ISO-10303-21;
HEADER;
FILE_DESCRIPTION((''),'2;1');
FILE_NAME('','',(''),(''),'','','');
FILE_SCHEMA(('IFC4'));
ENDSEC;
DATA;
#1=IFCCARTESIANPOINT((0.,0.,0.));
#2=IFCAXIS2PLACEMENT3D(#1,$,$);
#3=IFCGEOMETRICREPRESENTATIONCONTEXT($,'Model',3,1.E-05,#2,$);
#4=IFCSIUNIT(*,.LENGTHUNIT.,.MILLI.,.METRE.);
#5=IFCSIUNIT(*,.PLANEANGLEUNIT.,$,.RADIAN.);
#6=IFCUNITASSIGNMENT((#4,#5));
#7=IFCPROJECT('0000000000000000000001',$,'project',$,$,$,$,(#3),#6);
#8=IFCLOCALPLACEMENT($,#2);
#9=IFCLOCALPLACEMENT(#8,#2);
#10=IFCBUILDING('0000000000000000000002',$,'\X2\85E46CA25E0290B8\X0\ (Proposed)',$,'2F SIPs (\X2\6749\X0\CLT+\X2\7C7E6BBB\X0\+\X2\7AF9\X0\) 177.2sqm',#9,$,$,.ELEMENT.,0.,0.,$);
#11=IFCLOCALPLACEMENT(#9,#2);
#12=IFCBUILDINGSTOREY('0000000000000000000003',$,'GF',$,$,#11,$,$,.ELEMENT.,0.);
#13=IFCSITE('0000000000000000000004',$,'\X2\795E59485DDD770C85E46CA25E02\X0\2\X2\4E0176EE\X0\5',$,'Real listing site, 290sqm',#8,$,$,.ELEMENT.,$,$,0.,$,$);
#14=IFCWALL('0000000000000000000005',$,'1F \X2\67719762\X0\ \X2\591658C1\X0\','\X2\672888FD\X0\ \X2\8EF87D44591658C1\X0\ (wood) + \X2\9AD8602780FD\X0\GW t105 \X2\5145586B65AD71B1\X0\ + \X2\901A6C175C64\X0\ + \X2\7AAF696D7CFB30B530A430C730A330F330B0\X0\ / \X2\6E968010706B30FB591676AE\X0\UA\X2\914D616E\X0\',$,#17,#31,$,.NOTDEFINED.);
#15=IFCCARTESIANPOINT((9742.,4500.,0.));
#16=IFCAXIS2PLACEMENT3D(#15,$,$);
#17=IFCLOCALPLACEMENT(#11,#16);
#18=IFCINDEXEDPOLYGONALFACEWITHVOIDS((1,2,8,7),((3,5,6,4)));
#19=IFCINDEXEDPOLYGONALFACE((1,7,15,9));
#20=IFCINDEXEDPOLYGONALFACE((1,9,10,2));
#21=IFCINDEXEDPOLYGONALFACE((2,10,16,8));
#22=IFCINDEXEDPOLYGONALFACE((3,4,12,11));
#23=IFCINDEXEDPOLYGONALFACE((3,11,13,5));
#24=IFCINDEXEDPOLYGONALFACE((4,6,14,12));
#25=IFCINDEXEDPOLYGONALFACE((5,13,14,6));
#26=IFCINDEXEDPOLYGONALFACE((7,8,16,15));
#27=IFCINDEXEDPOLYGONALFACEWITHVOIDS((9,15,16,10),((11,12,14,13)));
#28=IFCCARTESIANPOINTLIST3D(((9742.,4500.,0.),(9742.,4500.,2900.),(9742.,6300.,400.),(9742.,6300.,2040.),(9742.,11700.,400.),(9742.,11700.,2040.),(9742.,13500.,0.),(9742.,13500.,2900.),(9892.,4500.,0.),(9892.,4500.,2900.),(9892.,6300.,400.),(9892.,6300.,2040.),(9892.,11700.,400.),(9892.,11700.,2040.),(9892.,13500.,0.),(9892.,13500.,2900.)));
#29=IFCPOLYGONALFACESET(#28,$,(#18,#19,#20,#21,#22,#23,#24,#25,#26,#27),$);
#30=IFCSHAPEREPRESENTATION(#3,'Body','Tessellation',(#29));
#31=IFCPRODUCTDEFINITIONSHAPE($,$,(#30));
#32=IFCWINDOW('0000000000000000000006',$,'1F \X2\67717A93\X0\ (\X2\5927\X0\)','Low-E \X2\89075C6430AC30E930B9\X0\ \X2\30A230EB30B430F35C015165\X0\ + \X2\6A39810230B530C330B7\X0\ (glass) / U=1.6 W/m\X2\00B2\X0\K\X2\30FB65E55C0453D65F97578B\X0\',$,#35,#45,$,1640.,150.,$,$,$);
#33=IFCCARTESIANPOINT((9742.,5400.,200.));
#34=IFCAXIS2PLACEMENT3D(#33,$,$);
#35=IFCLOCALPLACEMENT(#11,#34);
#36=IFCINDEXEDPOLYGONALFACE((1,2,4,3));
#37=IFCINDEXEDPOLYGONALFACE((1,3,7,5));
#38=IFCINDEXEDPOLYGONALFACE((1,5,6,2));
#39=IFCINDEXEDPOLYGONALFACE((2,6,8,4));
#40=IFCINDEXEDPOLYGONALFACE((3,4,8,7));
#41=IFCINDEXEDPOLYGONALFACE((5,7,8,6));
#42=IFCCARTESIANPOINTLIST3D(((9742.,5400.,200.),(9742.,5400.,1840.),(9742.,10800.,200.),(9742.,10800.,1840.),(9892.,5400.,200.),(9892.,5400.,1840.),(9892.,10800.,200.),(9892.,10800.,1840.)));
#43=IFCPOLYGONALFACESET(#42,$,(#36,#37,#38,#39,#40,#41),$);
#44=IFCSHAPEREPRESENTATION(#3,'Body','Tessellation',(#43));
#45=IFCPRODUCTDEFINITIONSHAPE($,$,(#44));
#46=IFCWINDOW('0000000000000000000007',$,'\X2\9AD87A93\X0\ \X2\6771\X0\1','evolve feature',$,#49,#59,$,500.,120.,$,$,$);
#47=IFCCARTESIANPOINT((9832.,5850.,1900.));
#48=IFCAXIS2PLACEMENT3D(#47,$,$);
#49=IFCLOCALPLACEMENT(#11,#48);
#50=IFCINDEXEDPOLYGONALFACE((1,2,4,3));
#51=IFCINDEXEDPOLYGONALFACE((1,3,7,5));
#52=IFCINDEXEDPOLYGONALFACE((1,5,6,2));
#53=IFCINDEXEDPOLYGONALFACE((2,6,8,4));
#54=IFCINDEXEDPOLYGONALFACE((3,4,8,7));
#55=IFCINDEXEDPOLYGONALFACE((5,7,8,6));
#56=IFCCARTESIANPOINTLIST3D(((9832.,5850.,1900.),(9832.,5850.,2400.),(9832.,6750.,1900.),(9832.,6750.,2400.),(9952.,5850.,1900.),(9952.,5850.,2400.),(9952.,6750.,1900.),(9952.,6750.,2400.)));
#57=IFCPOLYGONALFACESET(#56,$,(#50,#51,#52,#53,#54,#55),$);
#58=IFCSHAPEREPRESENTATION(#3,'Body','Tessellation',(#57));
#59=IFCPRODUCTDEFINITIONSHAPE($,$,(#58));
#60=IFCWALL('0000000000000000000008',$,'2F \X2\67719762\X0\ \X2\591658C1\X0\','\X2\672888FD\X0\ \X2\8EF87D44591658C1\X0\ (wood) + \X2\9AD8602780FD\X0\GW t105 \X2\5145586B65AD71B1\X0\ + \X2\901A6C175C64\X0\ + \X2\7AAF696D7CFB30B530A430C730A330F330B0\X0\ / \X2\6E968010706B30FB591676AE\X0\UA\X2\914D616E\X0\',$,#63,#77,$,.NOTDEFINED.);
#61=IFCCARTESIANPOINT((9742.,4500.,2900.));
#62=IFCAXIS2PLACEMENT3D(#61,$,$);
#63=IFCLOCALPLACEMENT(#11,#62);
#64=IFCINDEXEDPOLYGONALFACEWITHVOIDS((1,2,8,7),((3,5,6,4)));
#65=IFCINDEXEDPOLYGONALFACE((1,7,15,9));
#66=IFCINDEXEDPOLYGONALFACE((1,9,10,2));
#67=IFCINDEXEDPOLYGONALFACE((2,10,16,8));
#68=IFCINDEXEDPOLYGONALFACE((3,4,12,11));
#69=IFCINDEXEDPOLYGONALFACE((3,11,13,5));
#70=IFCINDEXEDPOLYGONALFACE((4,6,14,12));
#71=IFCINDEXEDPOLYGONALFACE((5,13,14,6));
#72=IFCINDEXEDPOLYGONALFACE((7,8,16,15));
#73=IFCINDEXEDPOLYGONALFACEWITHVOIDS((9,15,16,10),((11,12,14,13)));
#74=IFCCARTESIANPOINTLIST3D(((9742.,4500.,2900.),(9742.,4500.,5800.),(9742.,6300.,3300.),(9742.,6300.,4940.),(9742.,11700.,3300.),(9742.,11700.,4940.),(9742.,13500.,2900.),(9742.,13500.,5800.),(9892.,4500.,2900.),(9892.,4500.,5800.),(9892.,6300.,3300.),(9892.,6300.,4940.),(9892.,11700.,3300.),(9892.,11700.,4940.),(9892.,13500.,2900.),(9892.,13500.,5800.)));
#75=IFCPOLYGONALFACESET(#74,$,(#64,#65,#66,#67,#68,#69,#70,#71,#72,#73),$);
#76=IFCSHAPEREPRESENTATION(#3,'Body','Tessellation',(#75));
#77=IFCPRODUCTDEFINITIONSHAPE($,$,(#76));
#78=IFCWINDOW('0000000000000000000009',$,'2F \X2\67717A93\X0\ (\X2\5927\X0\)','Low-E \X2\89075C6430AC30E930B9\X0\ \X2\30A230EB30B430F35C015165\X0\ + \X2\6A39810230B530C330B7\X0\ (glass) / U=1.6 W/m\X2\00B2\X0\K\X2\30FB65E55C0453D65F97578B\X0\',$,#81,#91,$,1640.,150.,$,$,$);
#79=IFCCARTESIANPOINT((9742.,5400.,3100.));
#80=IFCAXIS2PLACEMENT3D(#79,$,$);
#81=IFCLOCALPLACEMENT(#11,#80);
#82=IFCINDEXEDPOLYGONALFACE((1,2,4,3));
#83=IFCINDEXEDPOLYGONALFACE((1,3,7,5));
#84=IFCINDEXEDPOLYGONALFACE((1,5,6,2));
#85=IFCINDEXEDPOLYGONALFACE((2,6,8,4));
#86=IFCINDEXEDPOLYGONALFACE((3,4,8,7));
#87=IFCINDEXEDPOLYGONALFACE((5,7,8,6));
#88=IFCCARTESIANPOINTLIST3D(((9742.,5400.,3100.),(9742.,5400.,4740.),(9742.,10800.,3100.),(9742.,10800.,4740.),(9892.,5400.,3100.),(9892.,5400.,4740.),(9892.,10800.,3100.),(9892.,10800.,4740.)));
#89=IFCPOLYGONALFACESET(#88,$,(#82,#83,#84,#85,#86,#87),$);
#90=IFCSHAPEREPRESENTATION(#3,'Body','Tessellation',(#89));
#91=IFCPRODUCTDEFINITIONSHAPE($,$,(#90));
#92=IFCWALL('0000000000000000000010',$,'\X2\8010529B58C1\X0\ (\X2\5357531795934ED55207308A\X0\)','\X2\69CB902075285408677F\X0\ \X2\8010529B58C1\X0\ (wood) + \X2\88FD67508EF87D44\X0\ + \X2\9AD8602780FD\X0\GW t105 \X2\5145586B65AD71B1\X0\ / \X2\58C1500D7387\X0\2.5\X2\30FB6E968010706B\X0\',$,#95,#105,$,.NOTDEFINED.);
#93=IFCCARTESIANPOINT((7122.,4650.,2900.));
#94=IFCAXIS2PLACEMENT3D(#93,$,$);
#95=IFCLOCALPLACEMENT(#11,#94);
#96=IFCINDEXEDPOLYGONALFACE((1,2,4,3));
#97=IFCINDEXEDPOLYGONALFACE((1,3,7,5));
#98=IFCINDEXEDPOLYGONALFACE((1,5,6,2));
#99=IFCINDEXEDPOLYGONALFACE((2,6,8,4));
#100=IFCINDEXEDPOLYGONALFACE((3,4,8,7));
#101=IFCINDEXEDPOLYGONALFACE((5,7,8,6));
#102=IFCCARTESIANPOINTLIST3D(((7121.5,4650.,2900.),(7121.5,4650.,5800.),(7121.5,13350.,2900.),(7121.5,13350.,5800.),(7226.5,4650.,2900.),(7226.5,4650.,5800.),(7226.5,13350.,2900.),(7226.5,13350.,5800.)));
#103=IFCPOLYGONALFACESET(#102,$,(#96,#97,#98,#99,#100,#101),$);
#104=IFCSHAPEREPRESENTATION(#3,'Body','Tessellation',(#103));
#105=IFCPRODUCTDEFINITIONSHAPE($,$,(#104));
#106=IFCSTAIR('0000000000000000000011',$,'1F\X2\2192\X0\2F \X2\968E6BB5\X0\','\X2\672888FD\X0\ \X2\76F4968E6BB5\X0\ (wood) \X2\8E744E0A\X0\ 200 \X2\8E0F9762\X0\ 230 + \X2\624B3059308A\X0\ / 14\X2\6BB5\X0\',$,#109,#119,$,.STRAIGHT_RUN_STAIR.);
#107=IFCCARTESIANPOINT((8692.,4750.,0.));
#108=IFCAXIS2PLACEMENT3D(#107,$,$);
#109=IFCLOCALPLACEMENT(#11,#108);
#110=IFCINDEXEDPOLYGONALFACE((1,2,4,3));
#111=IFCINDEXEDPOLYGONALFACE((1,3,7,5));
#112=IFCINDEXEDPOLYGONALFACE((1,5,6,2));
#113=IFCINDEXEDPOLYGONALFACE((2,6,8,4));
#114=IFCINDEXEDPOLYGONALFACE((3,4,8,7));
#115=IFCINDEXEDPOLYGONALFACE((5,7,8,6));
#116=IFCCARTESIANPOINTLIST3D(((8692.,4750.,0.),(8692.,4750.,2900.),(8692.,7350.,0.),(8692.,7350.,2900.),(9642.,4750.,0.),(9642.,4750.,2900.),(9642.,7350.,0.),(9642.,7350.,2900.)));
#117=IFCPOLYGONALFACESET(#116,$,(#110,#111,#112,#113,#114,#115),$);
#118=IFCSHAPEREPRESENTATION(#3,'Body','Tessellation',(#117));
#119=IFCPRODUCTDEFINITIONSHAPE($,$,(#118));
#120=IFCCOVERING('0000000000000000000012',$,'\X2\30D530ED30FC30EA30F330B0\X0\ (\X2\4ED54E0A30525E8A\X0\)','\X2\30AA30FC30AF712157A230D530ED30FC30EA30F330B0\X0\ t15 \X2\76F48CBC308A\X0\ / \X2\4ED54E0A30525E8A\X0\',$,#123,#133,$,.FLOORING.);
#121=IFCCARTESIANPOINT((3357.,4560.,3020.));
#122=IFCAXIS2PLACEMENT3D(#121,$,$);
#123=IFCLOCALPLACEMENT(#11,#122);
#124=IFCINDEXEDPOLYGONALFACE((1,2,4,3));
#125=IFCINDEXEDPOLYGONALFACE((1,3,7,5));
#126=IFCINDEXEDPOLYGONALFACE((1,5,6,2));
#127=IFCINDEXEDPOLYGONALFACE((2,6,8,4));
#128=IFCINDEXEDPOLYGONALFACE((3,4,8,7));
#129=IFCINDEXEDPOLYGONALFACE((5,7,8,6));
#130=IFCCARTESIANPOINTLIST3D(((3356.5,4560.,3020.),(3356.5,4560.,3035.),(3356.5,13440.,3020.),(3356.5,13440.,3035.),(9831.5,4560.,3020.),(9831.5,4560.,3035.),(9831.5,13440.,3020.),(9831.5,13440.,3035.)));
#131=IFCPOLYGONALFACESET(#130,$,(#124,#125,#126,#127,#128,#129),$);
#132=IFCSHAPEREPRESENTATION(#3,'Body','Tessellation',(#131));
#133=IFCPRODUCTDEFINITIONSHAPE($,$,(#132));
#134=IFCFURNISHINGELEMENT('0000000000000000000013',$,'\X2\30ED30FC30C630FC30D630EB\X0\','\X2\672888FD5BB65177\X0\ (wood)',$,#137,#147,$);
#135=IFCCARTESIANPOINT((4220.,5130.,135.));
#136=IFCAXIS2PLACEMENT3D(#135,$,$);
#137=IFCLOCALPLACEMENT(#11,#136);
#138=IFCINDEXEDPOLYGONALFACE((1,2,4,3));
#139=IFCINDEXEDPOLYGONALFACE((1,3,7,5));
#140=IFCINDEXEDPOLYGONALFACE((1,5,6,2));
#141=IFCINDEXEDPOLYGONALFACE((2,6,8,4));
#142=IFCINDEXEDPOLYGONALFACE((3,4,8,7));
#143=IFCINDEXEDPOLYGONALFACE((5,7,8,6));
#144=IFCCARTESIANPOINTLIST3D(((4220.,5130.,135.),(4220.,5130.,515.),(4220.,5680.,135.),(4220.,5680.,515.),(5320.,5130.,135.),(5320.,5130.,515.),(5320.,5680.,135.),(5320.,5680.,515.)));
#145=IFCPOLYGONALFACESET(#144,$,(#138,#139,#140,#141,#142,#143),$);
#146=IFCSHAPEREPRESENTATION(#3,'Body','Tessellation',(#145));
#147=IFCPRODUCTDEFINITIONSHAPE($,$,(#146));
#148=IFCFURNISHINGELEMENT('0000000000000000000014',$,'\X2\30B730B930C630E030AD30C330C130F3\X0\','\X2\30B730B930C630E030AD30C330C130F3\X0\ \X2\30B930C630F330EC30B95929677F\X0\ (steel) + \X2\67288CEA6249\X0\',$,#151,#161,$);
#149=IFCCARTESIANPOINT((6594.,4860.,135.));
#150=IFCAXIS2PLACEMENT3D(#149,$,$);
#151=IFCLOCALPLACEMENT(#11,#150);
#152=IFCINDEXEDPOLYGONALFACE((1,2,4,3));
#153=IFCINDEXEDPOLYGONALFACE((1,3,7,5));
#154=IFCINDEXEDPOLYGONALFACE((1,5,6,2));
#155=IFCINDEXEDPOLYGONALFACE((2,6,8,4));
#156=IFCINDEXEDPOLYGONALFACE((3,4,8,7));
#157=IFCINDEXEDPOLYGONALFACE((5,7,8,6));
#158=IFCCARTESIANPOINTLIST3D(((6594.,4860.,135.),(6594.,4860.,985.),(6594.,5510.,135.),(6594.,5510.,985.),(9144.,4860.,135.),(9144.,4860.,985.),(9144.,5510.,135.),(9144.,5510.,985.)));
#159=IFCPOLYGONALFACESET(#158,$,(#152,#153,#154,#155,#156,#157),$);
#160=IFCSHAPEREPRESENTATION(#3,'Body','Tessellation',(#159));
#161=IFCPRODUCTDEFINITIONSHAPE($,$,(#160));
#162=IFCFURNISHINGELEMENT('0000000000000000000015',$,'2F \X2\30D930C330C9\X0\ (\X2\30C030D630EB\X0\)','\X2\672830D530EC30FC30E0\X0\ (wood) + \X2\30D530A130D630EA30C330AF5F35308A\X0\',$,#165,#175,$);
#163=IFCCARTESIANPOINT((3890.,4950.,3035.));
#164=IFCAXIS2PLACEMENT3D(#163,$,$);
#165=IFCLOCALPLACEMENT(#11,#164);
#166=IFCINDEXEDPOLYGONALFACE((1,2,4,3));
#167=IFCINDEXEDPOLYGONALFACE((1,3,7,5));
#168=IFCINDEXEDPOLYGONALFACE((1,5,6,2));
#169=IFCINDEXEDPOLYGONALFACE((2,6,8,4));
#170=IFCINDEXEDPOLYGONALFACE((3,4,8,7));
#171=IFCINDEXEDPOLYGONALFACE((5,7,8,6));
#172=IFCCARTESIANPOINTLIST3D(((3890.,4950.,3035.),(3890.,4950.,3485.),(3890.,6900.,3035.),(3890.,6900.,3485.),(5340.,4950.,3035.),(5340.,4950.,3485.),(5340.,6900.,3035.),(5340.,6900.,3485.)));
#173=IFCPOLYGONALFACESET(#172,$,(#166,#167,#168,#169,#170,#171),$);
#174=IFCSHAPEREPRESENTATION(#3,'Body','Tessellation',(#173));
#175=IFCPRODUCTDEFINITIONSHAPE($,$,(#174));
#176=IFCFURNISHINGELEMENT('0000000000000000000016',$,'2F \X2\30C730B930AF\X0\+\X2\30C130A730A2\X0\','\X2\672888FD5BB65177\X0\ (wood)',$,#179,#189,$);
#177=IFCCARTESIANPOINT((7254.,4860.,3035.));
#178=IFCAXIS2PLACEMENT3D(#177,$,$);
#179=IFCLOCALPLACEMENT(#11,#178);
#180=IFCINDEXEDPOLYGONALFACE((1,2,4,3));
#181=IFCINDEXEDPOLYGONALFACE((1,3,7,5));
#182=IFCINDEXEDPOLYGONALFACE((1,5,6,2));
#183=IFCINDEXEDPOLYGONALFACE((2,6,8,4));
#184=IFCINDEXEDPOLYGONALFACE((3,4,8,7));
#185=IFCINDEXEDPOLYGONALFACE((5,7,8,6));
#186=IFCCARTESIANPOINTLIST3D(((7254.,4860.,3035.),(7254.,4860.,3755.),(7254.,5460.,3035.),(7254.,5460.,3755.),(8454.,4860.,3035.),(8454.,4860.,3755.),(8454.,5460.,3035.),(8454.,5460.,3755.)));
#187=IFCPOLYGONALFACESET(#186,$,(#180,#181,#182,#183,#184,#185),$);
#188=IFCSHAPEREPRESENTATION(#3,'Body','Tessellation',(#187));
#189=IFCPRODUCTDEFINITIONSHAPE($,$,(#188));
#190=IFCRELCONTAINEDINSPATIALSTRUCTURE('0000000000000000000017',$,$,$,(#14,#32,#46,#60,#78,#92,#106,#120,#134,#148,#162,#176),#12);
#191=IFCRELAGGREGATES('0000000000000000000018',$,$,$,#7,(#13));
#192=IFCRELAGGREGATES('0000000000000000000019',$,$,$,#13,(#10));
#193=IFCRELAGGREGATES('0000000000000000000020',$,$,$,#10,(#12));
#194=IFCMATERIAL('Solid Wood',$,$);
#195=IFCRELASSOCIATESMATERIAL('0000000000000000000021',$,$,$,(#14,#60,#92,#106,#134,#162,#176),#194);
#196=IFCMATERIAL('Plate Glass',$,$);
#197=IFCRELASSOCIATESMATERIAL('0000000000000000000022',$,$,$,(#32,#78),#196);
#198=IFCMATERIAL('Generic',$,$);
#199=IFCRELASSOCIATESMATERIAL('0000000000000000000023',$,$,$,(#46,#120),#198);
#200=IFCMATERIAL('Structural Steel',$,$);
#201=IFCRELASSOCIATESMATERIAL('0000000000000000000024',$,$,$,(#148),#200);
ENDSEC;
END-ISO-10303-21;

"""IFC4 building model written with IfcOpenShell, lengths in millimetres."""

from ifc_helpers import new_model, si_unit, frame, frame_2d, origin, place, context, project, spatial, rectangle, extrude, material, element, fill, save


model = new_model("IFC4")

# Units and contexts
model_context = context("Model", 3, precision=1e-05, world=origin())
ifc_project = project(units=[si_unit("LENGTHUNIT", "METRE", prefix="MILLI"), si_unit("PLANEANGLEUNIT", "RADIAN")], contexts=[model_context])

# Site, building, storey
site_placement = place(None, origin())
site = spatial("IfcSite", under=ifc_project, at=site_placement, Name="神奈川県藤沢市2丁目5", ObjectType="Real listing site, 290sqm", CompositionType="ELEMENT", RefElevation=0.0)
building_placement = place(site_placement, origin())
building = spatial("IfcBuilding", under=site, at=building_placement, Name="藤沢市邸 (Proposed)", ObjectType="2F SIPs (杉CLT+籾殻+竹) 177.2sqm", CompositionType="ELEMENT", ElevationOfRefHeight=0.0, ElevationOfTerrain=0.0)
storey_placement = place(building_placement, origin())
storey = spatial("IfcBuildingStorey", under=building, at=storey_placement, Name="GF", CompositionType="ELEMENT", Elevation=0.0)

# Shared definitions
ifc_material_1 = material(Name="Solid Wood")

# Wall, openings, windows
wall_1_placement = place(storey_placement, frame((9742.0, 4500.0, 0.0)))
wall_1 = element("IfcWall", 1, at=wall_1_placement, inside=storey, material=ifc_material_1, Name="1F 東面 外壁", Description="木製 軸組外壁 (wood) + 高性能GW t105 充填断熱 + 通気層 + 窯業系サイディング / 準耐火・外皮UA配慮", PredefinedType="NOTDEFINED", context=model_context, shape_type="SweptSolid", body=[
    extrude(rectangle(XDim=150.0, YDim=9000.0, at=frame_2d((75.0, 4500.0))), frame((9742.0, 4500.0, 0.0)), (0.0, 0.0, 1.0), 2900.0),
])
opening_1_placement = place(storey_placement, frame((9742.0, 5400.0, 200.0)))
opening_1 = element("IfcOpeningElement", 2, at=opening_1_placement, cuts=wall_1, PredefinedType="NOTDEFINED", context=model_context, shape_type="SweptSolid", body=[
    extrude(rectangle(XDim=150.0, YDim=5400.0, at=frame_2d((75.0, 2700.0))), frame((9742.0, 5400.0, 200.0)), (0.0, 0.0, 1.0), 1640.0),
])
opening_2_placement = place(storey_placement, frame((9832.0, 5850.0, 1900.0)))
opening_2 = element("IfcOpeningElement", 3, at=opening_2_placement, cuts=wall_1, PredefinedType="NOTDEFINED", context=model_context, shape_type="SweptSolid", body=[
    extrude(rectangle(XDim=120.0, YDim=900.0, at=frame_2d((60.0, 450.0))), frame((9832.0, 5850.0, 1900.0)), (0.0, 0.0, 1.0), 500.0),
])
ifc_material_2 = material(Name="Plate Glass")
window_1_placement = place(storey_placement, frame((9742.0, 5400.0, 200.0)))
window_1 = element("IfcWindow", 4, at=window_1_placement, inside=storey, material=ifc_material_2, Name="1F 東窓 (大)", Description="Low-E 複層ガラス アルゴン封入 + 樹脂サッシ (glass) / U=1.6 W/m²K・日射取得型", OverallHeight=1640.0, OverallWidth=150.0, context=model_context, shape_type="SweptSolid", body=[
    extrude(rectangle(XDim=150.0, YDim=5400.0, at=frame_2d((75.0, 2700.0))), frame((9742.0, 5400.0, 200.0)), (0.0, 0.0, 1.0), 1640.0),
])
fill(opening_1, window_1)
ifc_material_3 = material(Name="Generic")
window_2_placement = place(storey_placement, frame((9832.0, 5850.0, 1900.0)))
window_2 = element("IfcWindow", 5, at=window_2_placement, inside=storey, material=ifc_material_3, Name="高窓 東1", Description="evolve feature", OverallHeight=500.0, OverallWidth=120.0, context=model_context, shape_type="SweptSolid", body=[
    extrude(rectangle(XDim=120.0, YDim=900.0, at=frame_2d((60.0, 450.0))), frame((9832.0, 5850.0, 1900.0)), (0.0, 0.0, 1.0), 500.0),
])
fill(opening_2, window_2)

# Wall, opening, window
wall_2_placement = place(storey_placement, frame((9742.0, 4500.0, 2900.0)))
wall_2 = element("IfcWall", 6, at=wall_2_placement, inside=storey, material=ifc_material_1, Name="2F 東面 外壁", Description="木製 軸組外壁 (wood) + 高性能GW t105 充填断熱 + 通気層 + 窯業系サイディング / 準耐火・外皮UA配慮", PredefinedType="NOTDEFINED", context=model_context, shape_type="SweptSolid", body=[
    extrude(rectangle(XDim=150.0, YDim=9000.0, at=frame_2d((75.0, 4500.0))), frame((9742.0, 4500.0, 2900.0)), (0.0, 0.0, 1.0), 2900.0),
])
opening_3_placement = place(storey_placement, frame((9742.0, 5400.0, 3100.0)))
opening_3 = element("IfcOpeningElement", 7, at=opening_3_placement, cuts=wall_2, PredefinedType="NOTDEFINED", context=model_context, shape_type="SweptSolid", body=[
    extrude(rectangle(XDim=150.0, YDim=5400.0, at=frame_2d((75.0, 2700.0))), frame((9742.0, 5400.0, 3100.0)), (0.0, 0.0, 1.0), 1640.0),
])
window_3_placement = place(storey_placement, frame((9742.0, 5400.0, 3100.0)))
window_3 = element("IfcWindow", 8, at=window_3_placement, inside=storey, material=ifc_material_2, Name="2F 東窓 (大)", Description="Low-E 複層ガラス アルゴン封入 + 樹脂サッシ (glass) / U=1.6 W/m²K・日射取得型", OverallHeight=1640.0, OverallWidth=150.0, context=model_context, shape_type="SweptSolid", body=[
    extrude(rectangle(XDim=150.0, YDim=5400.0, at=frame_2d((75.0, 2700.0))), frame((9742.0, 5400.0, 3100.0)), (0.0, 0.0, 1.0), 1640.0),
])
fill(opening_3, window_3)

# Wall
wall_3_placement = place(storey_placement, frame((7122.0, 4650.0, 2900.0)))
element("IfcWall", 9, at=wall_3_placement, inside=storey, material=ifc_material_1, Name="耐力壁 (南北間仕切り)", Description="構造用合板 耐力壁 (wood) + 製材軸組 + 高性能GW t105 充填断熱 / 壁倍率2.5・準耐火", PredefinedType="NOTDEFINED", context=model_context, shape_type="SweptSolid", body=[
    extrude(rectangle(XDim=105.0, YDim=8700.0, at=frame_2d((52.0, 4350.0))), frame((7122.0, 4650.0, 2900.0)), (0.0, 0.0, 1.0), 2900.0),
])

# Stair
stair_placement = place(storey_placement, frame((8692.0, 4750.0, 0.0)))
element("IfcStair", 10, at=stair_placement, inside=storey, material=ifc_material_1, Name="1F→2F 階段", Description="木製 直階段 (wood) 蹴上 200 踏面 230 + 手すり / 14段", PredefinedType="STRAIGHT_RUN_STAIR", context=model_context, shape_type="SweptSolid", body=[
    extrude(rectangle(XDim=950.0, YDim=2600.0, at=frame_2d((475.0, 1300.0))), frame((8692.0, 4750.0, 0.0)), (0.0, 0.0, 1.0), 2900.0),
])

# Covering
covering_placement = place(storey_placement, frame((3357.0, 4560.0, 3020.0)))
element("IfcCovering", 11, at=covering_placement, inside=storey, material=ifc_material_3, Name="フローリング (仕上げ床)", Description="オーク無垢フローリング t15 直貼り / 仕上げ床", PredefinedType="FLOORING", context=model_context, shape_type="SweptSolid", body=[
    extrude(rectangle(XDim=6475.0, YDim=8880.0, at=frame_2d((3237.0, 4440.0))), frame((3357.0, 4560.0, 3020.0)), (0.0, 0.0, 1.0), 15.0),
])

# Furnishing elements
furnishing_1_placement = place(storey_placement, frame((4220.0, 5130.0, 135.0)))
element("IfcFurnishingElement", 12, at=furnishing_1_placement, inside=storey, material=ifc_material_1, Name="ローテーブル", Description="木製家具 (wood)", context=model_context, shape_type="SweptSolid", body=[
    extrude(rectangle(XDim=1100.0, YDim=550.0, at=frame_2d((550.0, 275.0))), frame((4220.0, 5130.0, 135.0)), (0.0, 0.0, 1.0), 380.0),
])
ifc_material_4 = material(Name="Structural Steel")
furnishing_2_placement = place(storey_placement, frame((6594.0, 4860.0, 135.0)))
element("IfcFurnishingElement", 13, at=furnishing_2_placement, inside=storey, material=ifc_material_4, Name="システムキッチン", Description="システムキッチン ステンレス天板 (steel) + 木質扉", context=model_context, shape_type="SweptSolid", body=[
    extrude(rectangle(XDim=2550.0, YDim=650.0, at=frame_2d((1275.0, 325.0))), frame((6594.0, 4860.0, 135.0)), (0.0, 0.0, 1.0), 850.0),
])
furnishing_3_placement = place(storey_placement, frame((3890.0, 4950.0, 3035.0)))
element("IfcFurnishingElement", 14, at=furnishing_3_placement, inside=storey, material=ifc_material_1, Name="2F ベッド (ダブル)", Description="木フレーム (wood) + ファブリック張り", context=model_context, shape_type="SweptSolid", body=[
    extrude(rectangle(XDim=1450.0, YDim=1950.0, at=frame_2d((725.0, 975.0))), frame((3890.0, 4950.0, 3035.0)), (0.0, 0.0, 1.0), 450.0),
])
furnishing_4_placement = place(storey_placement, frame((7254.0, 4860.0, 3035.0)))
element("IfcFurnishingElement", 15, at=furnishing_4_placement, inside=storey, material=ifc_material_1, Name="2F デスク+チェア", Description="木製家具 (wood)", context=model_context, shape_type="SweptSolid", body=[
    extrude(rectangle(XDim=1200.0, YDim=600.0, at=frame_2d((600.0, 300.0))), frame((7254.0, 4860.0, 3035.0)), (0.0, 0.0, 1.0), 720.0),
])

save(model, "model.ifc")
